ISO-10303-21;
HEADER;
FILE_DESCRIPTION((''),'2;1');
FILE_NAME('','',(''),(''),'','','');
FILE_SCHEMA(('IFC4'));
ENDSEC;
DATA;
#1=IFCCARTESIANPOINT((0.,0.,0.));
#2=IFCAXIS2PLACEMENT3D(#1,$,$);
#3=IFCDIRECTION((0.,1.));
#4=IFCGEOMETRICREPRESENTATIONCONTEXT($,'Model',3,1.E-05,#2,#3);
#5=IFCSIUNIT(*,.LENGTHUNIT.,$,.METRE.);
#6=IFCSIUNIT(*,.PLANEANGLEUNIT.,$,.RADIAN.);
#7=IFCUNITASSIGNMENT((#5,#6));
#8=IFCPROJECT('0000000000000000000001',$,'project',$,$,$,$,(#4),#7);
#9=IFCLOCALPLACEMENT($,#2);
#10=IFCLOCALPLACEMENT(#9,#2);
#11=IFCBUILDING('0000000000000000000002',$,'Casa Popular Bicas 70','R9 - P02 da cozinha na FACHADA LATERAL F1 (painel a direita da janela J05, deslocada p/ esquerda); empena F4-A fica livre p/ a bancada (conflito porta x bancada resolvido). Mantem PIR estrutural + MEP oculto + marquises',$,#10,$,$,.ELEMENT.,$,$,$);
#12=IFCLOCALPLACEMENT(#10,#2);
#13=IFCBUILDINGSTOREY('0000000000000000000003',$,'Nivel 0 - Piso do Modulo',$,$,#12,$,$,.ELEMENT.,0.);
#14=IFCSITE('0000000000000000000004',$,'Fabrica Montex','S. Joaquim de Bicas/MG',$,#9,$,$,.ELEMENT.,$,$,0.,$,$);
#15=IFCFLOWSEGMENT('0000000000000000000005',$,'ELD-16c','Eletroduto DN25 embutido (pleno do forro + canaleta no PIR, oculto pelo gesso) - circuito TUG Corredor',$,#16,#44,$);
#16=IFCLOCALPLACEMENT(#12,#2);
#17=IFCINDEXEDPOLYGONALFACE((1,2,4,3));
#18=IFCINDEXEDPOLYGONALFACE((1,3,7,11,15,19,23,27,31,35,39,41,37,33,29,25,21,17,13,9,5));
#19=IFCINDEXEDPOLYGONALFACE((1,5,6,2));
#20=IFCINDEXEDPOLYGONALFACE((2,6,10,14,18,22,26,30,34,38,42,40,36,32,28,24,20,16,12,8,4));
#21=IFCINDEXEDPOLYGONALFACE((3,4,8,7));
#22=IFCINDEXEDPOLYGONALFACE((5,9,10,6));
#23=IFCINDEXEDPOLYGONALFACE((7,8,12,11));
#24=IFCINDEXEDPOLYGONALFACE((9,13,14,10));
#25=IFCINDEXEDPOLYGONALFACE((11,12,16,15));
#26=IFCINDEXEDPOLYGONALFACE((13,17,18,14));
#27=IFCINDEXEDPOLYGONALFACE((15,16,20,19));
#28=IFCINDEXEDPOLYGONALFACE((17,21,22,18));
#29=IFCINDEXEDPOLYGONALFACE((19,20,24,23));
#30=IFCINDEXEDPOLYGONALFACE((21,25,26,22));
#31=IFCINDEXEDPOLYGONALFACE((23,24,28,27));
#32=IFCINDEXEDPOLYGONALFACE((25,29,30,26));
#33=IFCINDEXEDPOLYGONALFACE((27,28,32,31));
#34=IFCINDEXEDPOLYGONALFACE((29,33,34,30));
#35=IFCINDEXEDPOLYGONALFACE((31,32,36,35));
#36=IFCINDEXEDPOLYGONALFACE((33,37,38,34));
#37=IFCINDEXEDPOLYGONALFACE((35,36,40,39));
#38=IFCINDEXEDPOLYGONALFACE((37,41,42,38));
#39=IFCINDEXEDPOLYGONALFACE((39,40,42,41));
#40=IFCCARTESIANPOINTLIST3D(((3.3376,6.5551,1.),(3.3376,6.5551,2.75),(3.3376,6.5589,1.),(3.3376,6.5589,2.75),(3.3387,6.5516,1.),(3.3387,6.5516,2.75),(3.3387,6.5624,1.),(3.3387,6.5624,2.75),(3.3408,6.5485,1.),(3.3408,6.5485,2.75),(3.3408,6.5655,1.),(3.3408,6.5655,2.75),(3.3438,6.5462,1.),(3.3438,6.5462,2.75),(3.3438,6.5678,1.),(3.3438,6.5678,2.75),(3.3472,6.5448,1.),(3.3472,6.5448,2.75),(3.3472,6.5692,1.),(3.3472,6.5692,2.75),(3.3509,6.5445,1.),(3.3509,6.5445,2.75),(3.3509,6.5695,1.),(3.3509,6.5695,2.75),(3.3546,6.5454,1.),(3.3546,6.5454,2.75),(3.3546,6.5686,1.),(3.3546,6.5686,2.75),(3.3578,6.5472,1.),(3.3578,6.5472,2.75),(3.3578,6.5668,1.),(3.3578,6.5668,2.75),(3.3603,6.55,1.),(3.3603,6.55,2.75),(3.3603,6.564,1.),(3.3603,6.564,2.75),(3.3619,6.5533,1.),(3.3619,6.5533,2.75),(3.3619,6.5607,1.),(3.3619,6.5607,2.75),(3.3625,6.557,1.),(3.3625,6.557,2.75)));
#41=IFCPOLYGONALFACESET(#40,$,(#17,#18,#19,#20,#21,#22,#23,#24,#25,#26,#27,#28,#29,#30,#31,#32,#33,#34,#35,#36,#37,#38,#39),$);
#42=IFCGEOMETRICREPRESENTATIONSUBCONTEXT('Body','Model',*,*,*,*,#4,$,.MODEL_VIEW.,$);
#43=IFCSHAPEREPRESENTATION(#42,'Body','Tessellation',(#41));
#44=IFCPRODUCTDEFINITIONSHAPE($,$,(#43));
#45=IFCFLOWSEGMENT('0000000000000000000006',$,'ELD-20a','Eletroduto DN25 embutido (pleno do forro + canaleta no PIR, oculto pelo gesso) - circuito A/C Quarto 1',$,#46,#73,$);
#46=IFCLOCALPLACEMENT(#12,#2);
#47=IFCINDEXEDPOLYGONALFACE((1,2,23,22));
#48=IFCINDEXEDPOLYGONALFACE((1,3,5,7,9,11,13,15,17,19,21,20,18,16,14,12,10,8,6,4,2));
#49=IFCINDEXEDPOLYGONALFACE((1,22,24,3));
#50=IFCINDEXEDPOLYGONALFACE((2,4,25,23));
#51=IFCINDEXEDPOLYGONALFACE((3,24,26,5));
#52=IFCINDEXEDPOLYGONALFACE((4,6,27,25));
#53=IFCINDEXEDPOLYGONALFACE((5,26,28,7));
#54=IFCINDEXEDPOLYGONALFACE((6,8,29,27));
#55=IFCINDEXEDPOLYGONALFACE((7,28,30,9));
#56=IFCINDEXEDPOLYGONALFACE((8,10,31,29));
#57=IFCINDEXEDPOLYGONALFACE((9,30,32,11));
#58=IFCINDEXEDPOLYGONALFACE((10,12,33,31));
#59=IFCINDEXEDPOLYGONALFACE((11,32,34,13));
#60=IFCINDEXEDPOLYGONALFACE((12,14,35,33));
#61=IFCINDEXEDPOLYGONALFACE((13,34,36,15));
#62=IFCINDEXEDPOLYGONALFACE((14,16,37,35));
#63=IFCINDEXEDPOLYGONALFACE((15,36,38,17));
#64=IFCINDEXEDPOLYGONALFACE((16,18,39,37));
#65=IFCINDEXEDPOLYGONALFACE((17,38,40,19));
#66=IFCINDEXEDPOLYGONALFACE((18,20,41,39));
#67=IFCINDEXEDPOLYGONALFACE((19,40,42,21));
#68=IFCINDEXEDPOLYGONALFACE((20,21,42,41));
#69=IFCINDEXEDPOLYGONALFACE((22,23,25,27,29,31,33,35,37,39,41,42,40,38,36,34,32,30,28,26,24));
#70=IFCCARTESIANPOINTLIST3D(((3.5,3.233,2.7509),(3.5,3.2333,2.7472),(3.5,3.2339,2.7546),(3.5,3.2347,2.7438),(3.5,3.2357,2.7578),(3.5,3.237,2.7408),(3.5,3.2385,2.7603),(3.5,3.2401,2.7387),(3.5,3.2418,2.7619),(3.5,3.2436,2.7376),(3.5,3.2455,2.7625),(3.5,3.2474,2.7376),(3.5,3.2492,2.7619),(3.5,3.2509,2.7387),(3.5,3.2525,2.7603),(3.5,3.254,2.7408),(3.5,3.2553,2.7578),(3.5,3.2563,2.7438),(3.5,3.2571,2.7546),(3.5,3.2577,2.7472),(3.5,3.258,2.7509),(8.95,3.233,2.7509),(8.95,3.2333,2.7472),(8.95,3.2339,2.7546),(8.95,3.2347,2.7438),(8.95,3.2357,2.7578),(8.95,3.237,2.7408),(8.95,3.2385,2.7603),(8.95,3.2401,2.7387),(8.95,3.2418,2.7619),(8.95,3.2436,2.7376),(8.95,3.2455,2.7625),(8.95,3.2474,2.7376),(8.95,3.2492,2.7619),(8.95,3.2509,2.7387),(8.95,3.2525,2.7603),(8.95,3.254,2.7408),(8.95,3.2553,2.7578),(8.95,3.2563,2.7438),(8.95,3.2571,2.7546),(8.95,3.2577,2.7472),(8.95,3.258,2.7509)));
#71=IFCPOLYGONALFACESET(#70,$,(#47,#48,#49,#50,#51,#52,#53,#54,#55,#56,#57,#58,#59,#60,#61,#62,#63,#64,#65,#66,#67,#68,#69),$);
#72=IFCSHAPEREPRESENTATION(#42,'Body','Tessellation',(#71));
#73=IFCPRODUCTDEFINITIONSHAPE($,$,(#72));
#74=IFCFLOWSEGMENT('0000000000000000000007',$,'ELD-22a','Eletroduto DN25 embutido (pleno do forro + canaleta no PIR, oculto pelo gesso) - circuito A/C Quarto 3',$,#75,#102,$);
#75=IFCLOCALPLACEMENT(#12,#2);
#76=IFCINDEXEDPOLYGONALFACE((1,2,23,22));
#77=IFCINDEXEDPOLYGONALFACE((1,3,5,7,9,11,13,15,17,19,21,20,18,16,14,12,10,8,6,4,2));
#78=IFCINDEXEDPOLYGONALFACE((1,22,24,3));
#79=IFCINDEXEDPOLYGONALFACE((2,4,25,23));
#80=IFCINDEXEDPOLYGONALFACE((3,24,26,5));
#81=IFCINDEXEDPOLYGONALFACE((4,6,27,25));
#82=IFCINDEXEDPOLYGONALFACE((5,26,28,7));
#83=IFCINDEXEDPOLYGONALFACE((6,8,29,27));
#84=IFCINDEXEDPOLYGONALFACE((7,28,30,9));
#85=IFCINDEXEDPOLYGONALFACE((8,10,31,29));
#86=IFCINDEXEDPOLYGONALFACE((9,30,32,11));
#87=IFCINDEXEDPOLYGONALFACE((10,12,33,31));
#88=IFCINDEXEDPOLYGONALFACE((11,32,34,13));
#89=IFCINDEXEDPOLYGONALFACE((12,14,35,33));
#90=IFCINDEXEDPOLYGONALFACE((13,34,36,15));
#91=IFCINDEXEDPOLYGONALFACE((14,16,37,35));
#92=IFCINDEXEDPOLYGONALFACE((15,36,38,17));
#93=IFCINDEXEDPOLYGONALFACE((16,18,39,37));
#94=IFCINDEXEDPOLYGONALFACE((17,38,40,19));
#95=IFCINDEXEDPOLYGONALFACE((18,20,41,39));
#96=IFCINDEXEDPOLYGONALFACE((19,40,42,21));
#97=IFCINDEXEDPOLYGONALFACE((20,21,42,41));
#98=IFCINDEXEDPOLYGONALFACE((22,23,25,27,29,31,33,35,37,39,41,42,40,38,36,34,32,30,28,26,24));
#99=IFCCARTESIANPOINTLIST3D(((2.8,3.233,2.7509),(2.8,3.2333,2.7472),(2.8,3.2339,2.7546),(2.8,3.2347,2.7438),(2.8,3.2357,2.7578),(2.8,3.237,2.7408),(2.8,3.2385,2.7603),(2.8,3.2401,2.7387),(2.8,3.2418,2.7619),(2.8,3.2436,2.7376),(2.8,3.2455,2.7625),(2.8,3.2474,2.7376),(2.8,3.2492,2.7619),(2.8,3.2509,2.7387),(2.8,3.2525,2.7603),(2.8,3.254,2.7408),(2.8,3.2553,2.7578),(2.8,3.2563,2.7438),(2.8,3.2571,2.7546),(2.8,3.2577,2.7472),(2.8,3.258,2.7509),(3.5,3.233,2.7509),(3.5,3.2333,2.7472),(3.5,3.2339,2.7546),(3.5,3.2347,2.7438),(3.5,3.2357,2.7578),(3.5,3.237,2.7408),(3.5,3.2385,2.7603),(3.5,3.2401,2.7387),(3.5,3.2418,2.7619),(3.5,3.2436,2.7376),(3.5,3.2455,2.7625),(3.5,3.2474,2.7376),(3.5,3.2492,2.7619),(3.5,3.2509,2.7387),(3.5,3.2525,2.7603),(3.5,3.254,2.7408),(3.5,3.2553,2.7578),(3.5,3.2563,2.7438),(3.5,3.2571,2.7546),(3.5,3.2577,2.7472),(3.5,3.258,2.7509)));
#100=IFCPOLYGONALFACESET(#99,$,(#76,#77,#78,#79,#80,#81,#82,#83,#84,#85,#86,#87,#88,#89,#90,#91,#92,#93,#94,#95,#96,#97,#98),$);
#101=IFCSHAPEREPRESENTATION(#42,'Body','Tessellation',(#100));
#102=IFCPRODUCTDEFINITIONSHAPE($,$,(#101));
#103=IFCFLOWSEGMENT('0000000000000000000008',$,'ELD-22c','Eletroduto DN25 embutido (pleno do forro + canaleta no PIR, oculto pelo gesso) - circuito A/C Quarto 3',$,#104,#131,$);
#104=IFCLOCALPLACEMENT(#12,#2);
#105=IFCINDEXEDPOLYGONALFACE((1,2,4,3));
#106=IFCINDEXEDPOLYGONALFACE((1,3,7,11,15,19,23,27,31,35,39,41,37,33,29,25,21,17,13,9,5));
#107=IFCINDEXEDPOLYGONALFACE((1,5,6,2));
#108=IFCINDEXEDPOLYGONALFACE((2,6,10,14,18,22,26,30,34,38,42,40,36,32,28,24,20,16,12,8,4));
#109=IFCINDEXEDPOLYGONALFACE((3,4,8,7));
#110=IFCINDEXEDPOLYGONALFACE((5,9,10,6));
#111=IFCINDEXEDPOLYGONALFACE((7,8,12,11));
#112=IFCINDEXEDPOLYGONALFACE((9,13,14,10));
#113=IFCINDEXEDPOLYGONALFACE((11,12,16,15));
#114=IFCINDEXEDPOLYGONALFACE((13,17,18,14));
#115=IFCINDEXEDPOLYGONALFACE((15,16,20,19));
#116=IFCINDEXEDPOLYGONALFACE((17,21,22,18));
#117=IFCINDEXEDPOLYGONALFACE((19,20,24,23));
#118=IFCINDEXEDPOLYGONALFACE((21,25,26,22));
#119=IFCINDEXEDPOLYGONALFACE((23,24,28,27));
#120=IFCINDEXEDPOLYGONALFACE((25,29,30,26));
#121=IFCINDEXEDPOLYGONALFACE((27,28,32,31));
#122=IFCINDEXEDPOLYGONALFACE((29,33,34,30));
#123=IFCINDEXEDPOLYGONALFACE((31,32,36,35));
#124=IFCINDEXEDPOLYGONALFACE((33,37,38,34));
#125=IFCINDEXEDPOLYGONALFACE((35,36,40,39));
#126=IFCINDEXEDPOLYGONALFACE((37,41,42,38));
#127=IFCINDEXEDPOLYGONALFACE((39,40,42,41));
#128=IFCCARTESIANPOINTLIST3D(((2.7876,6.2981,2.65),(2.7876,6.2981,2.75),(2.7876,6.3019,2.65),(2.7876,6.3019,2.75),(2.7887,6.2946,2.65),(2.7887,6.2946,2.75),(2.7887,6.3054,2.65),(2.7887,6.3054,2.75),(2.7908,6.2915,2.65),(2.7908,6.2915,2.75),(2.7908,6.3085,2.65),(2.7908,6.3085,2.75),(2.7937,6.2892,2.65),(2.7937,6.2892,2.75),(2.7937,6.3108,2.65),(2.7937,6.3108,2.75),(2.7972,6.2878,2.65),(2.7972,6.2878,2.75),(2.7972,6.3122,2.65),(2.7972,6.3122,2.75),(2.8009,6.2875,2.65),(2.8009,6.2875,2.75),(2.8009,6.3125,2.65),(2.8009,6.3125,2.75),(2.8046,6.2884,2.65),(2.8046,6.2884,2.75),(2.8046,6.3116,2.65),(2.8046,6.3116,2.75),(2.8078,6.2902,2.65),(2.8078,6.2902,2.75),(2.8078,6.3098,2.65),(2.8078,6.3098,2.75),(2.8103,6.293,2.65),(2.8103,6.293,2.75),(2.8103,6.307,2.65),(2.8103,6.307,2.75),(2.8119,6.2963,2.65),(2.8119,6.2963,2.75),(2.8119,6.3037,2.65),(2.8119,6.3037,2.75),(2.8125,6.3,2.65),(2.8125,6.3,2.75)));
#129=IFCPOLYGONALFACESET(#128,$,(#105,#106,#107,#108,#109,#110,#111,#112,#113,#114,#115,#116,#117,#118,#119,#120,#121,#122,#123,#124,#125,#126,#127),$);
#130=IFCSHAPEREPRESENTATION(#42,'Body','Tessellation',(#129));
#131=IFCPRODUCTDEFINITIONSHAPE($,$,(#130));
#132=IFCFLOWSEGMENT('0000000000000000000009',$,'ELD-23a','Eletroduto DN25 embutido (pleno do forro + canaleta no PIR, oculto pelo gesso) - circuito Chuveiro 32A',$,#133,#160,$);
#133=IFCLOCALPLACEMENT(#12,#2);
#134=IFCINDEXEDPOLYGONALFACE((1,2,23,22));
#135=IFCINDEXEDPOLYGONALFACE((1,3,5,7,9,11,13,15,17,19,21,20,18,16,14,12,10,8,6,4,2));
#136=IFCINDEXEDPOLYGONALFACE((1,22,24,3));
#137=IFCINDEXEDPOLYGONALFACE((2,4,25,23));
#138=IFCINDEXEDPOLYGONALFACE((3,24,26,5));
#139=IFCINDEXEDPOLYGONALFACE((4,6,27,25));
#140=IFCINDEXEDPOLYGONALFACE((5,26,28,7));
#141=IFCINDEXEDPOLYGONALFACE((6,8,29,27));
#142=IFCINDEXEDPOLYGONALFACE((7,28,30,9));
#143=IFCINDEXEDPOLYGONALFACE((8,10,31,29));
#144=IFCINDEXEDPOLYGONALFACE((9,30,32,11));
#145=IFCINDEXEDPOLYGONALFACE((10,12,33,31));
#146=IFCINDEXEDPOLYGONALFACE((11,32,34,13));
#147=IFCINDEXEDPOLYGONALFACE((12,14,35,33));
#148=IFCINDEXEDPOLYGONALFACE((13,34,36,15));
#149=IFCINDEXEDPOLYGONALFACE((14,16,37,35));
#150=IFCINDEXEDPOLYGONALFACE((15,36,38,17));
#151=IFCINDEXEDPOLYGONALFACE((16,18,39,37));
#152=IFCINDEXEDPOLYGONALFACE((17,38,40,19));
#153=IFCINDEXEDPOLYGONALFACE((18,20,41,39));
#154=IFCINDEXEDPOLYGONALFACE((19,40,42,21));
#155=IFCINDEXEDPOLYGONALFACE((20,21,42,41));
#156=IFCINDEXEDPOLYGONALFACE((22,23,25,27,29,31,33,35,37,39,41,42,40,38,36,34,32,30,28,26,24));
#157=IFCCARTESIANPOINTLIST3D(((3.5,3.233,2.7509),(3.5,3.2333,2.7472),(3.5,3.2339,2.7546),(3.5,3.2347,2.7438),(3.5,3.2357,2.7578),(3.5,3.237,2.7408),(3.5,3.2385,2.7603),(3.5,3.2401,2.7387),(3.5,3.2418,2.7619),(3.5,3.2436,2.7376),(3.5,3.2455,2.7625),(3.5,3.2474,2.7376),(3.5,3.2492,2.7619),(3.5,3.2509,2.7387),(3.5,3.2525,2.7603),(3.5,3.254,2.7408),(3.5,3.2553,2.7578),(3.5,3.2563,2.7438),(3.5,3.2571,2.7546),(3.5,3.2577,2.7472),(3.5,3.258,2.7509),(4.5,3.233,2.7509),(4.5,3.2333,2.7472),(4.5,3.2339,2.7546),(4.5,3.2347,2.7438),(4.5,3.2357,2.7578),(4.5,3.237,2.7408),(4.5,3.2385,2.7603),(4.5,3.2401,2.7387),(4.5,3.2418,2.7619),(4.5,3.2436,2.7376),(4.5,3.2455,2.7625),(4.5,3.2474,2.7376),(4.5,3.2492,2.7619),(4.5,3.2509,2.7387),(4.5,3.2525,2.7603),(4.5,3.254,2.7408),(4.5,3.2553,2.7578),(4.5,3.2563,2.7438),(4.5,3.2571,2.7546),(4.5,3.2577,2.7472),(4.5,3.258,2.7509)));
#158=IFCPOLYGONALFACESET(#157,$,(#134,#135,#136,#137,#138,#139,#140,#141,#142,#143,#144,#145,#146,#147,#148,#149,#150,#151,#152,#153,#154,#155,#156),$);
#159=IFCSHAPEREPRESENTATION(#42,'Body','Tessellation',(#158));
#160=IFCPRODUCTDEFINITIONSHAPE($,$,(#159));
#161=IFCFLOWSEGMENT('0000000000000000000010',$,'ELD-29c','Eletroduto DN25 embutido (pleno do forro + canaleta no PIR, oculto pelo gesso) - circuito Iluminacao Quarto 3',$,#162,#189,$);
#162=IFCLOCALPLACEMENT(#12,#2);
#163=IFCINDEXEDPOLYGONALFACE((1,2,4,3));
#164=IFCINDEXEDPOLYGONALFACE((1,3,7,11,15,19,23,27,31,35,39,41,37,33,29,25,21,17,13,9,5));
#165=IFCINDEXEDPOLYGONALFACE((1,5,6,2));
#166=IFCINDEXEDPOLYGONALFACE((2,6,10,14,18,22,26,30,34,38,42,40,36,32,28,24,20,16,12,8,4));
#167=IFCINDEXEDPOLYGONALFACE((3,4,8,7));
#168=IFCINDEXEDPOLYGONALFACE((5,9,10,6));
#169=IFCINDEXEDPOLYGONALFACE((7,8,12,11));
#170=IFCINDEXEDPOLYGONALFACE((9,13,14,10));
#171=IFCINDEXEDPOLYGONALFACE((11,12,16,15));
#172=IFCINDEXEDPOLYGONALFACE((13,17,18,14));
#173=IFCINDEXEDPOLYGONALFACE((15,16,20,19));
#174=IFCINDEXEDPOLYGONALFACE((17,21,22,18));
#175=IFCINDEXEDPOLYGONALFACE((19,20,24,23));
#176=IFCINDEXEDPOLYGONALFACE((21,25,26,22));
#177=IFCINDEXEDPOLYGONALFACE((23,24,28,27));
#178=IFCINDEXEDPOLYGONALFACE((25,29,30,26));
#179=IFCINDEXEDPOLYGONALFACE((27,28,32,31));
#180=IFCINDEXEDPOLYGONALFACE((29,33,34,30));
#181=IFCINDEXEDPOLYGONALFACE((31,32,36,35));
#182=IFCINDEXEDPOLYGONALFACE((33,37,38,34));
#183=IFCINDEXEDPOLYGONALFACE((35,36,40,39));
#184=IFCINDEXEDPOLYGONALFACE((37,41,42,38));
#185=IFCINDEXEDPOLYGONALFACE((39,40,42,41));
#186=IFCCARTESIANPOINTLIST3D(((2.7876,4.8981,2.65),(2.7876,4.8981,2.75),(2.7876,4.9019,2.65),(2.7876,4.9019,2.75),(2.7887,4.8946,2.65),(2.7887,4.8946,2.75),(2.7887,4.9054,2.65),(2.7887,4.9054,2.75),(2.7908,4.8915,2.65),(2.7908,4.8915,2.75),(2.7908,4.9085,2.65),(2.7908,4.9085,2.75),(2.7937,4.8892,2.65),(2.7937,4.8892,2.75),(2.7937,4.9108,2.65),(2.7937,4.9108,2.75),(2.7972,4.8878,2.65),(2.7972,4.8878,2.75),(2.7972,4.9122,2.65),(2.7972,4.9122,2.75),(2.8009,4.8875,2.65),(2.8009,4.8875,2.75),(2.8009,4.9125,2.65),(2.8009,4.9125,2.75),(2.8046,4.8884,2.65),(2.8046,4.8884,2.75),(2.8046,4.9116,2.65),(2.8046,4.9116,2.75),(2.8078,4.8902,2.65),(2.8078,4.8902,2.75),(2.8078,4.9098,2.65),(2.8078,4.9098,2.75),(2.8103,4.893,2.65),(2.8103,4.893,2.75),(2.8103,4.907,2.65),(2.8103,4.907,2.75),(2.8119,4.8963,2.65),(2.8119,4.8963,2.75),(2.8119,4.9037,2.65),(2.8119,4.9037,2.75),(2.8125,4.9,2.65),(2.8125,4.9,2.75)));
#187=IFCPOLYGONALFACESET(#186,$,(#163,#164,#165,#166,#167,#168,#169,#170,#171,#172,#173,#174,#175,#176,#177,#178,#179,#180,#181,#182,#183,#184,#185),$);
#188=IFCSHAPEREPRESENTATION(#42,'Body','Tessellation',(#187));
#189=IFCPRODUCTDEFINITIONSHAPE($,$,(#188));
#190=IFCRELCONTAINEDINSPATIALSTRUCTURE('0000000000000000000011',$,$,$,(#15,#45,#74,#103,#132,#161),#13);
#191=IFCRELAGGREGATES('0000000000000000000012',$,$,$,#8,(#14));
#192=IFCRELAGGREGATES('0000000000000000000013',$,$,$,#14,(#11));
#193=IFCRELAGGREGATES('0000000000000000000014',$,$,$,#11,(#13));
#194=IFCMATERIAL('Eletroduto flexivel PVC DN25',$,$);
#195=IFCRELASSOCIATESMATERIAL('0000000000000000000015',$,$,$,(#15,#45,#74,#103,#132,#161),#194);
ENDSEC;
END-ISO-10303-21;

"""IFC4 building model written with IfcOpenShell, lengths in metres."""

from ifc_helpers import new_model, si_unit, direction, frame, origin, origin_2d, place, context, subcontext, project, spatial, circle, extrude, material, element, save


model = new_model("IFC4")

# Units and contexts
model_context = context("Model", 3, precision=1e-05, world=origin(), true_north=direction((0.0, 1.0)))
body_context = subcontext(model_context, "Body", "Model", "MODEL_VIEW")
ifc_project = project(units=[si_unit("LENGTHUNIT", "METRE"), si_unit("PLANEANGLEUNIT", "RADIAN")], contexts=[model_context])

# Site, building, storey
site_placement = place(None, origin())
site = spatial("IfcSite", under=ifc_project, at=site_placement, Name="Fabrica Montex", Description="S. Joaquim de Bicas/MG", CompositionType="ELEMENT", RefElevation=0.0)
building_placement = place(site_placement, origin())
building = spatial("IfcBuilding", under=site, at=building_placement, Name="Casa Popular Bicas 70", Description="R9 - P02 da cozinha na FACHADA LATERAL F1 (painel a direita da janela J05, deslocada p/ esquerda); empena F4-A fica livre p/ a bancada (conflito porta x bancada resolvido). Mantem PIR estrutural + MEP oculto + marquises", CompositionType="ELEMENT")
storey_placement = place(building_placement, origin())
storey = spatial("IfcBuildingStorey", under=building, at=storey_placement, Name="Nivel 0 - Piso do Modulo", CompositionType="ELEMENT", Elevation=0.0)

# Flow segments
ifc_material_1 = material(Name="Eletroduto flexivel PVC DN25")
flow_segment_1_placement = place(storey_placement, frame((3.35, 6.557, 2.75), z_axis=(0.0, 0.0, -1.0), x_axis=(1.0, 0.0, 0.0)))
element("IfcFlowSegment", 1, at=flow_segment_1_placement, inside=storey, material=ifc_material_1, Name="ELD-16c", Description="Eletroduto DN25 embutido (pleno do forro + canaleta no PIR, oculto pelo gesso) - circuito TUG Corredor", context=body_context, shape_type="SweptSolid", body=[
    extrude(circle(Radius=0.0125, at=origin_2d()), origin(), (0.0, 0.0, 1.0), 1.75),
])
flow_segment_2_placement = place(storey_placement, frame((3.5, 3.2455, 2.75), z_axis=(1.0, 0.0, 0.0), x_axis=(0.0, 0.0, 1.0)))
element("IfcFlowSegment", 2, at=flow_segment_2_placement, inside=storey, material=ifc_material_1, Name="ELD-20a", Description="Eletroduto DN25 embutido (pleno do forro + canaleta no PIR, oculto pelo gesso) - circuito A/C Quarto 1", context=body_context, shape_type="SweptSolid", body=[
    extrude(circle(Radius=0.0125, at=origin_2d()), origin(), (0.0, 0.0, 1.0), 5.45),
])
flow_segment_3_placement = place(storey_placement, frame((3.5, 3.2455, 2.75), z_axis=(-1.0, 0.0, 0.0), x_axis=(0.0, 0.0, 1.0)))
element("IfcFlowSegment", 3, at=flow_segment_3_placement, inside=storey, material=ifc_material_1, Name="ELD-22a", Description="Eletroduto DN25 embutido (pleno do forro + canaleta no PIR, oculto pelo gesso) - circuito A/C Quarto 3", context=body_context, shape_type="SweptSolid", body=[
    extrude(circle(Radius=0.0125, at=origin_2d()), origin(), (0.0, 0.0, 1.0), 0.7),
])
flow_segment_4_placement = place(storey_placement, frame((2.8, 6.3, 2.75), z_axis=(0.0, 0.0, -1.0), x_axis=(1.0, 0.0, 0.0)))
element("IfcFlowSegment", 4, at=flow_segment_4_placement, inside=storey, material=ifc_material_1, Name="ELD-22c", Description="Eletroduto DN25 embutido (pleno do forro + canaleta no PIR, oculto pelo gesso) - circuito A/C Quarto 3", context=body_context, shape_type="SweptSolid", body=[
    extrude(circle(Radius=0.0125, at=origin_2d()), origin(), (0.0, 0.0, 1.0), 0.1),
])
flow_segment_5_placement = place(storey_placement, frame((3.5, 3.2455, 2.75), z_axis=(1.0, 0.0, 0.0), x_axis=(0.0, 0.0, 1.0)))
element("IfcFlowSegment", 5, at=flow_segment_5_placement, inside=storey, material=ifc_material_1, Name="ELD-23a", Description="Eletroduto DN25 embutido (pleno do forro + canaleta no PIR, oculto pelo gesso) - circuito Chuveiro 32A", context=body_context, shape_type="SweptSolid", body=[
    extrude(circle(Radius=0.0125, at=origin_2d()), origin(), (0.0, 0.0, 1.0), 1.0),
])
flow_segment_6_placement = place(storey_placement, frame((2.8, 4.9, 2.75), z_axis=(0.0, 0.0, -1.0), x_axis=(1.0, 0.0, 0.0)))
element("IfcFlowSegment", 6, at=flow_segment_6_placement, inside=storey, material=ifc_material_1, Name="ELD-29c", Description="Eletroduto DN25 embutido (pleno do forro + canaleta no PIR, oculto pelo gesso) - circuito Iluminacao Quarto 3", context=body_context, shape_type="SweptSolid", body=[
    extrude(circle(Radius=0.0125, at=origin_2d()), origin(), (0.0, 0.0, 1.0), 0.1),
])

save(model, "model.ifc")
